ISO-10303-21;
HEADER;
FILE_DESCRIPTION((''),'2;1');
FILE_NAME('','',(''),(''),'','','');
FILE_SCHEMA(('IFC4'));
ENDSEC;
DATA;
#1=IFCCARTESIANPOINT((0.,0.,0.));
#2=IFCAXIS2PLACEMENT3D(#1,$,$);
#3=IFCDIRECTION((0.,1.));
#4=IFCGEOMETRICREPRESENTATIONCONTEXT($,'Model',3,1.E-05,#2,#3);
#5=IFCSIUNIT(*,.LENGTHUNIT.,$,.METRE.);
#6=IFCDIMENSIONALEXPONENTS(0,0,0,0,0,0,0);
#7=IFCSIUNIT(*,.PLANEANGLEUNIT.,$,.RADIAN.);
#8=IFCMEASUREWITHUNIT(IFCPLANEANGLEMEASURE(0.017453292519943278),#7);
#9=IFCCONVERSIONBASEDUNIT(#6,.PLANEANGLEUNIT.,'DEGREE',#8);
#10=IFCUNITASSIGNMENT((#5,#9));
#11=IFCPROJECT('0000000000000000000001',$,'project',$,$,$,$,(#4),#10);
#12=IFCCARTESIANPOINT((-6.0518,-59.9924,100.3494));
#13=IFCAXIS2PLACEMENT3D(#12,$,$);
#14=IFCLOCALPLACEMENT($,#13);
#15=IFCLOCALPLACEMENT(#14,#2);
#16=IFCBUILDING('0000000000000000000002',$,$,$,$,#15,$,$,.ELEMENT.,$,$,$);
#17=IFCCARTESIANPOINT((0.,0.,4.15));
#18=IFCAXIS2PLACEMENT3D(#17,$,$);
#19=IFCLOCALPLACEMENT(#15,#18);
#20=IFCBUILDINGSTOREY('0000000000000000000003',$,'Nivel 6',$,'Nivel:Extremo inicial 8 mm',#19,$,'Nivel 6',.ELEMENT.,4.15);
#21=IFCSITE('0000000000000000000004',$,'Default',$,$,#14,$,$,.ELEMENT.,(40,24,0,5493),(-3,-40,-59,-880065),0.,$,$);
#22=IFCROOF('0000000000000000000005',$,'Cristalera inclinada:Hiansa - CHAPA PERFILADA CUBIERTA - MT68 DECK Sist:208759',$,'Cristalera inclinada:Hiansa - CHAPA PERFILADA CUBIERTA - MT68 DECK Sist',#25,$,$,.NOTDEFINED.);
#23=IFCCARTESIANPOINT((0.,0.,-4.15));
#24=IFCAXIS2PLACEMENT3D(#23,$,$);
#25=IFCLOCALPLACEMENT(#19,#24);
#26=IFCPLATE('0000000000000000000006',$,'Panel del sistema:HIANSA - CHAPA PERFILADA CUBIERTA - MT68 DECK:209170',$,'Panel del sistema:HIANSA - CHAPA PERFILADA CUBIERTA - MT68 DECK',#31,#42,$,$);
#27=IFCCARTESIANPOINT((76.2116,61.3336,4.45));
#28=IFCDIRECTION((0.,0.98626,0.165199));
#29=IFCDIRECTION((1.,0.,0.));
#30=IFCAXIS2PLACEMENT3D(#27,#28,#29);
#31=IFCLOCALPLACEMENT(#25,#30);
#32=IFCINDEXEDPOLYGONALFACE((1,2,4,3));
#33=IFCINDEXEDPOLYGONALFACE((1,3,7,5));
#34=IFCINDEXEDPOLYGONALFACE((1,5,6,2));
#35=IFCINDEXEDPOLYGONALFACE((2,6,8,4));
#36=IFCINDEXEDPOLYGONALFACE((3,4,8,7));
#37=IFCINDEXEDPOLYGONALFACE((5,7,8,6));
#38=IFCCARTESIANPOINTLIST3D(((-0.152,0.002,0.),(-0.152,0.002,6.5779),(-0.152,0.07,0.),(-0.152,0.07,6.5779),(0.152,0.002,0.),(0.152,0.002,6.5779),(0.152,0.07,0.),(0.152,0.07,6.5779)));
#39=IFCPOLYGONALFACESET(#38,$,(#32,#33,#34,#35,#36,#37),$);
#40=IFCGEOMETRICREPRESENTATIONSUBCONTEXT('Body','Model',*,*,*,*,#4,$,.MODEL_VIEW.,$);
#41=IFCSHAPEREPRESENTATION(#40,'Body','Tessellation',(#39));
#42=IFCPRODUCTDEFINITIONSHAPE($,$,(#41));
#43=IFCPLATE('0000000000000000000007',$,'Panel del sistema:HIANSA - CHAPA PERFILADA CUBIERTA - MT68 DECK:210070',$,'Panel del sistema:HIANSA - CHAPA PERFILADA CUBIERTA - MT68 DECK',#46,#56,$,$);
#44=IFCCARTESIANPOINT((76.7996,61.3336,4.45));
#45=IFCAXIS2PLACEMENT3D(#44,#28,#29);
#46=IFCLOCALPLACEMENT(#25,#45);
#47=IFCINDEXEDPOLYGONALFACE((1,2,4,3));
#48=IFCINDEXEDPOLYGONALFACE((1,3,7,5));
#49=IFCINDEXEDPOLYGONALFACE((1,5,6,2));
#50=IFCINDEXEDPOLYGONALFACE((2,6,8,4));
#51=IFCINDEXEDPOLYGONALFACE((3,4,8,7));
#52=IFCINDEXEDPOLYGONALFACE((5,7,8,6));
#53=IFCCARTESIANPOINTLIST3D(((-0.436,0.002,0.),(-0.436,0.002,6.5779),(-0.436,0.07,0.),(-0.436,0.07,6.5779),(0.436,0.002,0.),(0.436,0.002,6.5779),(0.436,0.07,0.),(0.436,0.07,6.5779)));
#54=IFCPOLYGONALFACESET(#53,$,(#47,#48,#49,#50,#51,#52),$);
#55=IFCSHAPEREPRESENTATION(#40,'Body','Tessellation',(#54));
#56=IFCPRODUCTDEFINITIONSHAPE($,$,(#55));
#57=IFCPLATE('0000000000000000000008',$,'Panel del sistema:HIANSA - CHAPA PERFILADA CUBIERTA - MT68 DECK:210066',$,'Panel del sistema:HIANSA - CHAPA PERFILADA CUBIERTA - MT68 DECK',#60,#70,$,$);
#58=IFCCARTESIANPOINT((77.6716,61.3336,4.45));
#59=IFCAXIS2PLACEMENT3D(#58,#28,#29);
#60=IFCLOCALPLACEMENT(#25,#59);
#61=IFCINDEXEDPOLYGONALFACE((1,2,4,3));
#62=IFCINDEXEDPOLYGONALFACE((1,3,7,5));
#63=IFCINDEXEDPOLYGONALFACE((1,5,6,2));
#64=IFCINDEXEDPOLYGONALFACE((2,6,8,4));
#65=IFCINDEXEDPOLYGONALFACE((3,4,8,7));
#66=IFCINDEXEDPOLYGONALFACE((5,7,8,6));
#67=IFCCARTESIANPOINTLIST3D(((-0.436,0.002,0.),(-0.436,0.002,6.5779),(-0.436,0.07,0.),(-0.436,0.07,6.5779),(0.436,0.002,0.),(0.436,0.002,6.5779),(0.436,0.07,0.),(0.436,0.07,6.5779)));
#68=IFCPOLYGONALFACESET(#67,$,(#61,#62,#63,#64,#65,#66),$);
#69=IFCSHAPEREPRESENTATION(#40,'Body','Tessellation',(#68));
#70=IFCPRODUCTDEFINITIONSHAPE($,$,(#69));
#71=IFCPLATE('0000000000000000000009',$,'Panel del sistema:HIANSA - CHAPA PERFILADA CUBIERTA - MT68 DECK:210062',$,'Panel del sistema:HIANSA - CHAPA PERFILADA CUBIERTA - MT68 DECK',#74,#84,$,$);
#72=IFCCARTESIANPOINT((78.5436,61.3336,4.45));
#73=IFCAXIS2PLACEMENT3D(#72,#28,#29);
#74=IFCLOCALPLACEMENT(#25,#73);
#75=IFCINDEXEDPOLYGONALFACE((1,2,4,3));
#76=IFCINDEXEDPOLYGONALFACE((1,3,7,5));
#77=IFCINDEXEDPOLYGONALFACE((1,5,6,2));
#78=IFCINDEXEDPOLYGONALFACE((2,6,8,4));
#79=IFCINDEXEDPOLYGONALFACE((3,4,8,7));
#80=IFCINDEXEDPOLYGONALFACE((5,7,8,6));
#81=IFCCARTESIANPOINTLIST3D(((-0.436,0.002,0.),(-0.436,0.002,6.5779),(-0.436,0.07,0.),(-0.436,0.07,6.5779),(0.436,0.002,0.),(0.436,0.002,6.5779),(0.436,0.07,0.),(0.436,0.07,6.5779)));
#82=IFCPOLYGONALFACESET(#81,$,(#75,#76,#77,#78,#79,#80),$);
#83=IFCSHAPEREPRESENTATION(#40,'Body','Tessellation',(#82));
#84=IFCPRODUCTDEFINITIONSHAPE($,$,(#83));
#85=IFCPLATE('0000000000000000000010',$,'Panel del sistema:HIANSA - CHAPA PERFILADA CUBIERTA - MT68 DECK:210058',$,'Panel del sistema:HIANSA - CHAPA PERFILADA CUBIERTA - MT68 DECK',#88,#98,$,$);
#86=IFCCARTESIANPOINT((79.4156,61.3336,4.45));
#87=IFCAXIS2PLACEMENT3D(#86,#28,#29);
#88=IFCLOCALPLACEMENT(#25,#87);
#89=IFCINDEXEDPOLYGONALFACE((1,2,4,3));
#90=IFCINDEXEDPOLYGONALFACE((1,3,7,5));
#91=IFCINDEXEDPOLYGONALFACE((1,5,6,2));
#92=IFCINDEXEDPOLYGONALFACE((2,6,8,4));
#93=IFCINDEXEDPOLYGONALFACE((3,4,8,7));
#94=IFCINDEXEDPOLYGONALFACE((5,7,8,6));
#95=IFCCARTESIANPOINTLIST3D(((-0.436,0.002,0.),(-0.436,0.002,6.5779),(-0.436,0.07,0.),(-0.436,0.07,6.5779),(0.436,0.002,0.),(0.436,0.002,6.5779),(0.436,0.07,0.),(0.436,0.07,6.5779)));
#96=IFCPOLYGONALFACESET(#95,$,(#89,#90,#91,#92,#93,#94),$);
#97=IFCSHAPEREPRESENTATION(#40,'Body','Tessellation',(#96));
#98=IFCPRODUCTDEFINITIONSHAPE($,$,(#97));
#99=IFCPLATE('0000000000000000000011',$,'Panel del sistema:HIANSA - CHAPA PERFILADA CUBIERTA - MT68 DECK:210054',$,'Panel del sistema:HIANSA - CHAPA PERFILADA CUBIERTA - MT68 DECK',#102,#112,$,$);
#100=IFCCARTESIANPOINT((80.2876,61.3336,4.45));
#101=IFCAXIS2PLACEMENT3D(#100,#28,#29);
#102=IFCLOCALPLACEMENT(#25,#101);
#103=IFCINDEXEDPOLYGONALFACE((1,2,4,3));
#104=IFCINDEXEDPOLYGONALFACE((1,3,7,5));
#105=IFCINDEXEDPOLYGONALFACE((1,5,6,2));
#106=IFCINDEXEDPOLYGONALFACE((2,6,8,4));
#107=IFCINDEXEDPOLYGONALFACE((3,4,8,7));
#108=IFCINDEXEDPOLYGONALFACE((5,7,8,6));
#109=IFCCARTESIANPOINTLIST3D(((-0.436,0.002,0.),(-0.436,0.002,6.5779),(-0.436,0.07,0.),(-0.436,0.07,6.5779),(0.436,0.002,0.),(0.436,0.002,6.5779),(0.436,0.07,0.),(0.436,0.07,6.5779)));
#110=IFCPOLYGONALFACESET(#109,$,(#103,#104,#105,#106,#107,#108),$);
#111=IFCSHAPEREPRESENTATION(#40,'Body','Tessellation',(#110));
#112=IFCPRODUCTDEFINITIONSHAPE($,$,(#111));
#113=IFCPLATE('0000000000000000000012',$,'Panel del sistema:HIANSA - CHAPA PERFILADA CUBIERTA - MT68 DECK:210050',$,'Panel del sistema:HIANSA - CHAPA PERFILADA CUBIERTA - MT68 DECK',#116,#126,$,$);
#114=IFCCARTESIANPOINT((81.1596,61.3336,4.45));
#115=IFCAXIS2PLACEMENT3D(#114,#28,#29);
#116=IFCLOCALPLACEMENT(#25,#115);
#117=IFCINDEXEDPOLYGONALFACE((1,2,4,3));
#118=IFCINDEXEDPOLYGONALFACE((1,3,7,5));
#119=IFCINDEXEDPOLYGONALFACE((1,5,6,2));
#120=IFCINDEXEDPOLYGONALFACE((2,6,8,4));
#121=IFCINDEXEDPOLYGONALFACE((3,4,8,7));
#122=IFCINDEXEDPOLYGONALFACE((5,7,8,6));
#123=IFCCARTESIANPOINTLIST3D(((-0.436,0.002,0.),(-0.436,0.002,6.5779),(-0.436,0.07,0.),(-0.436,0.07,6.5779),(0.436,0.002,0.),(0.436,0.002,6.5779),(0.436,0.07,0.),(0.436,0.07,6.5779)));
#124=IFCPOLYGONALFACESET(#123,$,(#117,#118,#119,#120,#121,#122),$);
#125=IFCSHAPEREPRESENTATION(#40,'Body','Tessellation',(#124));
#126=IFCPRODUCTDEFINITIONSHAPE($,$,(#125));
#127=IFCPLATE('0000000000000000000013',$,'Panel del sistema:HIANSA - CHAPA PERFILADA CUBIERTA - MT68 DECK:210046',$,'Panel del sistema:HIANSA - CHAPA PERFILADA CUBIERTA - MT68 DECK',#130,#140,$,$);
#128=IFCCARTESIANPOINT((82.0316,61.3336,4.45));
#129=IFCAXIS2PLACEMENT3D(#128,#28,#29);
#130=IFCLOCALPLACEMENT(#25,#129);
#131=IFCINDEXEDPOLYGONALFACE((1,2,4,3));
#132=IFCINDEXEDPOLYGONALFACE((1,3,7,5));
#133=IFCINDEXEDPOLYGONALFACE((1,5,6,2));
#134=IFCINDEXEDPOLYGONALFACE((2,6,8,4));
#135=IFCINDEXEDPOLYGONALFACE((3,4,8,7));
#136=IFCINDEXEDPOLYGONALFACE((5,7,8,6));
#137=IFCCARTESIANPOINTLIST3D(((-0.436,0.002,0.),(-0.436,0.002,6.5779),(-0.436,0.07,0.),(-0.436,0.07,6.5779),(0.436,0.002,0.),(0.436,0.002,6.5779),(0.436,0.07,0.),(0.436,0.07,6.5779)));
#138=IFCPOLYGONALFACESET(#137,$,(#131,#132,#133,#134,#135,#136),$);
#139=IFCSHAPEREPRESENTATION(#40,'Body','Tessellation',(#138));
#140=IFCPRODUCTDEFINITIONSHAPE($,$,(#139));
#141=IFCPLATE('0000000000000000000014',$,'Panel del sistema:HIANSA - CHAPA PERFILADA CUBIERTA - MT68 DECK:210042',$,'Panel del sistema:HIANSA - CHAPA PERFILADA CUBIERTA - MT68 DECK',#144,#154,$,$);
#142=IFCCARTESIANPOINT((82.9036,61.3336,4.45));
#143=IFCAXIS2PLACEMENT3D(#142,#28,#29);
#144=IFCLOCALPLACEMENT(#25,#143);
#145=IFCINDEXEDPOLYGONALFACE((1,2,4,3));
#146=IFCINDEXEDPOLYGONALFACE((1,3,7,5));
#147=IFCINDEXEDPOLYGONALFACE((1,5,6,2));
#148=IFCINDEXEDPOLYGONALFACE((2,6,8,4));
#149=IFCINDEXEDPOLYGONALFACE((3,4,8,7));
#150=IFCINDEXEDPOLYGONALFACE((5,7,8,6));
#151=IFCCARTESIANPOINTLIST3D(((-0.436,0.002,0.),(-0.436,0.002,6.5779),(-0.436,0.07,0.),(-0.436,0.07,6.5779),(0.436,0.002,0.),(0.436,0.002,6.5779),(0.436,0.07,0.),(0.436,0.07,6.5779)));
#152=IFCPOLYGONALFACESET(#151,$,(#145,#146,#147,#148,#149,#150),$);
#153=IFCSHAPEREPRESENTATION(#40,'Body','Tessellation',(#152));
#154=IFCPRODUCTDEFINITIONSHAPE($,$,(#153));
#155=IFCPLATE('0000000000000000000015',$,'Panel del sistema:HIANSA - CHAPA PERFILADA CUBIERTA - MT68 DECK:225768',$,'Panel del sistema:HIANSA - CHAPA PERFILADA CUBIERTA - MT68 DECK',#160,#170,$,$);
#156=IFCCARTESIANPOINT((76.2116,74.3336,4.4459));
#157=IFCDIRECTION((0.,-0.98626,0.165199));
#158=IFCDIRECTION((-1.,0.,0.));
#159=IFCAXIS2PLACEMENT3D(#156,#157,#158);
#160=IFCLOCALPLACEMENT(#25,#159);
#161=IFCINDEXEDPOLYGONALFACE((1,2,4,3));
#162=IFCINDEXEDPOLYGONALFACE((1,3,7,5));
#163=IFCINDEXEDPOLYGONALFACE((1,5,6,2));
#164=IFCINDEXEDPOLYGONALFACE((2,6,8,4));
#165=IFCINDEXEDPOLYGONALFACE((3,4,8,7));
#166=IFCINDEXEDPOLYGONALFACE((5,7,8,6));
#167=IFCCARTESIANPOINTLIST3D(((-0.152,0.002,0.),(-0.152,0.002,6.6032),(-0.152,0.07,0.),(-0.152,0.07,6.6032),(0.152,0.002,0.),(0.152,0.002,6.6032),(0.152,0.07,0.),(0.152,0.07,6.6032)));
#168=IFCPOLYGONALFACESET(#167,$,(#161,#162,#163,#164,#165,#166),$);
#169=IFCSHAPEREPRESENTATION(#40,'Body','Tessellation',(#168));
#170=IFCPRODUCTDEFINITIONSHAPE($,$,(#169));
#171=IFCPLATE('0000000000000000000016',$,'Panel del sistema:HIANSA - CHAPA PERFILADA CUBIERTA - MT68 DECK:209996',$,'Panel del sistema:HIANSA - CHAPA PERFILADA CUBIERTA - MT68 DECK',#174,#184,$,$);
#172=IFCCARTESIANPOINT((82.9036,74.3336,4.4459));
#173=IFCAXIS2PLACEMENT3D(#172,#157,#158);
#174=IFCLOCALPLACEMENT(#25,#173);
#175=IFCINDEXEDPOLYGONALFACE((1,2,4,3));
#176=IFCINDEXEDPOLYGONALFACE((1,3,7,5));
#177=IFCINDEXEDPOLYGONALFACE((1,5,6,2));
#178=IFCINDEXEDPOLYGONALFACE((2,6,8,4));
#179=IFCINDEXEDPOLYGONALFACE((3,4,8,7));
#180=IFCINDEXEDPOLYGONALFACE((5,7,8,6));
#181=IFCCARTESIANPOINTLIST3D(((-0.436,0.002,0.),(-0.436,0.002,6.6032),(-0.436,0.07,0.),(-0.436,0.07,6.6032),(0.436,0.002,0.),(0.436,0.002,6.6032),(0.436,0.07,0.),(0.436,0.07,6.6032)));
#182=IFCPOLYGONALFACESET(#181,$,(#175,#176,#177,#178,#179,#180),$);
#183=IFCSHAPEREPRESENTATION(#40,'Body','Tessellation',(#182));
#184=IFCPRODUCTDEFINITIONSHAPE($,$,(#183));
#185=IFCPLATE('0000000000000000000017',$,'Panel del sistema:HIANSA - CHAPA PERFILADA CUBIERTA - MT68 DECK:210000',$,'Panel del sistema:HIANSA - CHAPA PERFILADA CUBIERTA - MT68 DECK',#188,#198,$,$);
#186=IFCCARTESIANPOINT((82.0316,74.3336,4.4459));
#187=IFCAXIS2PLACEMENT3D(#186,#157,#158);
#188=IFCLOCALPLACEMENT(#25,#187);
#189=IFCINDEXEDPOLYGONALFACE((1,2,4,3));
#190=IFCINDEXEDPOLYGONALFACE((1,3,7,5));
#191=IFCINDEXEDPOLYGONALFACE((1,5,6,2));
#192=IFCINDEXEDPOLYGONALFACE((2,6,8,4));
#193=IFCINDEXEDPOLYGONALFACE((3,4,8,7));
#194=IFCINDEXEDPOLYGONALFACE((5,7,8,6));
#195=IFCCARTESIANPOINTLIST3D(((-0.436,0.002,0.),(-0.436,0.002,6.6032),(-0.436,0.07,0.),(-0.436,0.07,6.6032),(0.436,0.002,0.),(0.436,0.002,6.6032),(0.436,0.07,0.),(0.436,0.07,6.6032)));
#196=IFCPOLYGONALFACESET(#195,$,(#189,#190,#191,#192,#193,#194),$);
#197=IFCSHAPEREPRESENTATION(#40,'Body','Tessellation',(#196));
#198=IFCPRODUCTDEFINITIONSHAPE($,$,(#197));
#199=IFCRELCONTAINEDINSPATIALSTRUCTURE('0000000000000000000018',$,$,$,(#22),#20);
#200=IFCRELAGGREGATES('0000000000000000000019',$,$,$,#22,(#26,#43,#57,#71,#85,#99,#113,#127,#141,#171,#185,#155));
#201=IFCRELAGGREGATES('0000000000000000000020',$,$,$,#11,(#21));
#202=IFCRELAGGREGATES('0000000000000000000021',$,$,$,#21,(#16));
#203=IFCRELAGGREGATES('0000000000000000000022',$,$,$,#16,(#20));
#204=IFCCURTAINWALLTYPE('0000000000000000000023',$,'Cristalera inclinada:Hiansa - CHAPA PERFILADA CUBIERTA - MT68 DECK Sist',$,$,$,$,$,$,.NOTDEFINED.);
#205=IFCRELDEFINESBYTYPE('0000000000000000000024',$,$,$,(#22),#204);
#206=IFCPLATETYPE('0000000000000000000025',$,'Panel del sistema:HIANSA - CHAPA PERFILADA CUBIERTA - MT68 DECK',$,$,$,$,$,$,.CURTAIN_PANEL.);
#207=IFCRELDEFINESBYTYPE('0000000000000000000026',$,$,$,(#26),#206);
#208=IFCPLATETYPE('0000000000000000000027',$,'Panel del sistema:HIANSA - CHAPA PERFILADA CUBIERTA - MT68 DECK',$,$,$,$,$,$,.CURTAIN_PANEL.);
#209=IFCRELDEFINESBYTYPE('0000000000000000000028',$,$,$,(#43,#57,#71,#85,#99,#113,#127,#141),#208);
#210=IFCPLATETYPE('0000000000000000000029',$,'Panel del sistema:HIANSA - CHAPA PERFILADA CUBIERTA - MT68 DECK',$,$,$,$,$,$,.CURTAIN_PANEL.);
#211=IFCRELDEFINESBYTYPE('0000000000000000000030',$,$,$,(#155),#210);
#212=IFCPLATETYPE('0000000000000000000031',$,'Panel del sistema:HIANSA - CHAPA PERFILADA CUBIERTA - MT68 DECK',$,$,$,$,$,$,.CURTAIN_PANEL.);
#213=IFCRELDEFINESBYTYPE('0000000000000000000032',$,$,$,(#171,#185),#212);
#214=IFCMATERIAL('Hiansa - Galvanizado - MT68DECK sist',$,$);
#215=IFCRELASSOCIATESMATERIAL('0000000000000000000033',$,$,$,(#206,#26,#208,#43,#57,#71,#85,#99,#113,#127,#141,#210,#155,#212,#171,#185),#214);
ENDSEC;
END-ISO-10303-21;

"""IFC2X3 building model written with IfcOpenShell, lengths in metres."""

from ifc_helpers import new_model, entity, si_unit, converted_unit, direction, frame, origin, origin_2d_with_axis, place, context, subcontext, project, spatial, rectangle, extrude, source, transform, mapped, material, type_object, type_shapes, element, aggregate, save


model = new_model("IFC2X3")

# Units and contexts
model_context = context("Model", 3, precision=1e-05, world=origin(), true_north=direction((0.0, 1.0)))
body_context = subcontext(model_context, "Body", "Model", "MODEL_VIEW")
ifc_project = project(units=[si_unit("LENGTHUNIT", "METRE"), converted_unit("PLANEANGLEUNIT", "DEGREE", entity("IfcPlaneAngleMeasure", 0.017453292519943278), si_unit("PLANEANGLEUNIT", "RADIAN"), dimensions=[0, 0, 0, 0, 0, 0, 0])], contexts=[model_context])

# Site, building, storey
site_placement = place(None, frame((-6.0518, -59.9924, 100.3494)))
site = spatial("IfcSite", under=ifc_project, at=site_placement, Name="Default", CompositionType="ELEMENT", RefLatitude=(40, 24, 0, 5493), RefLongitude=(-3, -40, -59, -880065), RefElevation=0.0)
building_placement = place(site_placement, origin())
building = spatial("IfcBuilding", under=site, at=building_placement, CompositionType="ELEMENT")
storey_placement = place(building_placement, frame((0.0, 0.0, 4.15)))
storey = spatial("IfcBuildingStorey", under=building, at=storey_placement, Name="Nivel 6", ObjectType="Nivel:Extremo inicial 8 mm", LongName="Nivel 6", CompositionType="ELEMENT", Elevation=4.15)

# Roof, plates
curtain_wall_type = type_object("IfcCurtainWallType", Name="Cristalera inclinada:Hiansa - CHAPA PERFILADA CUBIERTA - MT68 DECK Sist", PredefinedType="NOTDEFINED")
roof_placement = place(storey_placement, frame((0.0, 0.0, -4.15)))
roof = element("IfcRoof", 1, at=roof_placement, inside=storey, type_object=curtain_wall_type, Name="Cristalera inclinada:Hiansa - CHAPA PERFILADA CUBIERTA - MT68 DECK Sist:208759", ObjectType="Cristalera inclinada:Hiansa - CHAPA PERFILADA CUBIERTA - MT68 DECK Sist", ShapeType="NOTDEFINED")
ifc_material_1 = material(Name="Hiansa - Galvanizado - MT68DECK sist")
plate_type_1 = type_object("IfcPlateType", Name="Panel del sistema:HIANSA - CHAPA PERFILADA CUBIERTA - MT68 DECK", PredefinedType="CURTAIN_PANEL", material=ifc_material_1)
shared_shape_1 = source(origin(), body_context, "Body", "SweptSolid", [
    extrude(rectangle(XDim=0.068, YDim=0.304, at=origin_2d_with_axis()), frame((0.0, 0.036, 0.0), z_axis=(0.0, 0.0, 1.0), x_axis=(0.0, 1.0, 0.0)), (0.0, 0.0, 1.0), 6.5779),
])
type_shapes(plate_type_1, [shared_shape_1])
plate_1_placement = place(roof_placement, frame((76.2116, 61.3336, 4.45), z_axis=(0.0, 0.98626, 0.165199), x_axis=(1.0, 0.0, 0.0)))
plate_1 = element("IfcPlate", 2, at=plate_1_placement, type_object=plate_type_1, material=ifc_material_1, Name="Panel del sistema:HIANSA - CHAPA PERFILADA CUBIERTA - MT68 DECK:209170", ObjectType="Panel del sistema:HIANSA - CHAPA PERFILADA CUBIERTA - MT68 DECK", context=body_context, shape_type="MappedRepresentation", body=[
    mapped(shared_shape_1, transform((0.0, 0.0, 0.0), scale=1.0)),
])
plate_type_2 = type_object("IfcPlateType", Name="Panel del sistema:HIANSA - CHAPA PERFILADA CUBIERTA - MT68 DECK", PredefinedType="CURTAIN_PANEL", material=ifc_material_1)
shared_shape_2 = source(origin(), body_context, "Body", "SweptSolid", [
    extrude(rectangle(XDim=0.068, YDim=0.872, at=origin_2d_with_axis()), frame((0.0, 0.036, 0.0), z_axis=(0.0, 0.0, 1.0), x_axis=(0.0, 1.0, 0.0)), (0.0, 0.0, 1.0), 6.5779),
])
type_shapes(plate_type_2, [shared_shape_2])
plate_2_placement = place(roof_placement, frame((76.7996, 61.3336, 4.45), z_axis=(0.0, 0.98626, 0.165199), x_axis=(1.0, 0.0, 0.0)))
plate_2 = element("IfcPlate", 3, at=plate_2_placement, type_object=plate_type_2, material=ifc_material_1, Name="Panel del sistema:HIANSA - CHAPA PERFILADA CUBIERTA - MT68 DECK:210070", ObjectType="Panel del sistema:HIANSA - CHAPA PERFILADA CUBIERTA - MT68 DECK", context=body_context, shape_type="MappedRepresentation", body=[
    mapped(shared_shape_2, transform((0.0, 0.0, 0.0), scale=1.0)),
])
plate_3_placement = place(roof_placement, frame((77.6716, 61.3336, 4.45), z_axis=(0.0, 0.98626, 0.165199), x_axis=(1.0, 0.0, 0.0)))
plate_3 = element("IfcPlate", 4, at=plate_3_placement, type_object=plate_type_2, material=ifc_material_1, Name="Panel del sistema:HIANSA - CHAPA PERFILADA CUBIERTA - MT68 DECK:210066", ObjectType="Panel del sistema:HIANSA - CHAPA PERFILADA CUBIERTA - MT68 DECK", context=body_context, shape_type="MappedRepresentation", body=[
    mapped(shared_shape_2, transform((0.0, 0.0, 0.0), scale=1.0)),
])
plate_4_placement = place(roof_placement, frame((78.5436, 61.3336, 4.45), z_axis=(0.0, 0.98626, 0.165199), x_axis=(1.0, 0.0, 0.0)))
plate_4 = element("IfcPlate", 5, at=plate_4_placement, type_object=plate_type_2, material=ifc_material_1, Name="Panel del sistema:HIANSA - CHAPA PERFILADA CUBIERTA - MT68 DECK:210062", ObjectType="Panel del sistema:HIANSA - CHAPA PERFILADA CUBIERTA - MT68 DECK", context=body_context, shape_type="MappedRepresentation", body=[
    mapped(shared_shape_2, transform((0.0, 0.0, 0.0), scale=1.0)),
])
plate_5_placement = place(roof_placement, frame((79.4156, 61.3336, 4.45), z_axis=(0.0, 0.98626, 0.165199), x_axis=(1.0, 0.0, 0.0)))
plate_5 = element("IfcPlate", 6, at=plate_5_placement, type_object=plate_type_2, material=ifc_material_1, Name="Panel del sistema:HIANSA - CHAPA PERFILADA CUBIERTA - MT68 DECK:210058", ObjectType="Panel del sistema:HIANSA - CHAPA PERFILADA CUBIERTA - MT68 DECK", context=body_context, shape_type="MappedRepresentation", body=[
    mapped(shared_shape_2, transform((0.0, 0.0, 0.0), scale=1.0)),
])
plate_6_placement = place(roof_placement, frame((80.2876, 61.3336, 4.45), z_axis=(0.0, 0.98626, 0.165199), x_axis=(1.0, 0.0, 0.0)))
plate_6 = element("IfcPlate", 7, at=plate_6_placement, type_object=plate_type_2, material=ifc_material_1, Name="Panel del sistema:HIANSA - CHAPA PERFILADA CUBIERTA - MT68 DECK:210054", ObjectType="Panel del sistema:HIANSA - CHAPA PERFILADA CUBIERTA - MT68 DECK", context=body_context, shape_type="MappedRepresentation", body=[
    mapped(shared_shape_2, transform((0.0, 0.0, 0.0), scale=1.0)),
])
plate_7_placement = place(roof_placement, frame((81.1596, 61.3336, 4.45), z_axis=(0.0, 0.98626, 0.165199), x_axis=(1.0, 0.0, 0.0)))
plate_7 = element("IfcPlate", 8, at=plate_7_placement, type_object=plate_type_2, material=ifc_material_1, Name="Panel del sistema:HIANSA - CHAPA PERFILADA CUBIERTA - MT68 DECK:210050", ObjectType="Panel del sistema:HIANSA - CHAPA PERFILADA CUBIERTA - MT68 DECK", context=body_context, shape_type="MappedRepresentation", body=[
    mapped(shared_shape_2, transform((0.0, 0.0, 0.0), scale=1.0)),
])
plate_8_placement = place(roof_placement, frame((82.0316, 61.3336, 4.45), z_axis=(0.0, 0.98626, 0.165199), x_axis=(1.0, 0.0, 0.0)))
plate_8 = element("IfcPlate", 9, at=plate_8_placement, type_object=plate_type_2, material=ifc_material_1, Name="Panel del sistema:HIANSA - CHAPA PERFILADA CUBIERTA - MT68 DECK:210046", ObjectType="Panel del sistema:HIANSA - CHAPA PERFILADA CUBIERTA - MT68 DECK", context=body_context, shape_type="MappedRepresentation", body=[
    mapped(shared_shape_2, transform((0.0, 0.0, 0.0), scale=1.0)),
])
plate_9_placement = place(roof_placement, frame((82.9036, 61.3336, 4.45), z_axis=(0.0, 0.98626, 0.165199), x_axis=(1.0, 0.0, 0.0)))
plate_9 = element("IfcPlate", 10, at=plate_9_placement, type_object=plate_type_2, material=ifc_material_1, Name="Panel del sistema:HIANSA - CHAPA PERFILADA CUBIERTA - MT68 DECK:210042", ObjectType="Panel del sistema:HIANSA - CHAPA PERFILADA CUBIERTA - MT68 DECK", context=body_context, shape_type="MappedRepresentation", body=[
    mapped(shared_shape_2, transform((0.0, 0.0, 0.0), scale=1.0)),
])
plate_type_3 = type_object("IfcPlateType", Name="Panel del sistema:HIANSA - CHAPA PERFILADA CUBIERTA - MT68 DECK", PredefinedType="CURTAIN_PANEL", material=ifc_material_1)
shared_shape_3 = source(origin(), body_context, "Body", "SweptSolid", [
    extrude(rectangle(XDim=0.068, YDim=0.304, at=origin_2d_with_axis()), frame((0.0, 0.036, 0.0), z_axis=(0.0, 0.0, 1.0), x_axis=(0.0, 1.0, 0.0)), (0.0, 0.0, 1.0), 6.6032),
])
type_shapes(plate_type_3, [shared_shape_3])
plate_10_placement = place(roof_placement, frame((76.2116, 74.3336, 4.4459), z_axis=(0.0, -0.98626, 0.165199), x_axis=(-1.0, 0.0, 0.0)))
plate_10 = element("IfcPlate", 11, at=plate_10_placement, type_object=plate_type_3, material=ifc_material_1, Name="Panel del sistema:HIANSA - CHAPA PERFILADA CUBIERTA - MT68 DECK:225768", ObjectType="Panel del sistema:HIANSA - CHAPA PERFILADA CUBIERTA - MT68 DECK", context=body_context, shape_type="MappedRepresentation", body=[
    mapped(shared_shape_3, transform((0.0, 0.0, 0.0), scale=1.0)),
])
plate_type_4 = type_object("IfcPlateType", Name="Panel del sistema:HIANSA - CHAPA PERFILADA CUBIERTA - MT68 DECK", PredefinedType="CURTAIN_PANEL", material=ifc_material_1)
shared_shape_4 = source(origin(), body_context, "Body", "SweptSolid", [
    extrude(rectangle(XDim=0.068, YDim=0.872, at=origin_2d_with_axis()), frame((0.0, 0.036, 0.0), z_axis=(0.0, 0.0, 1.0), x_axis=(0.0, 1.0, 0.0)), (0.0, 0.0, 1.0), 6.6032),
])
type_shapes(plate_type_4, [shared_shape_4])
plate_11_placement = place(roof_placement, frame((82.9036, 74.3336, 4.4459), z_axis=(0.0, -0.98626, 0.165199), x_axis=(-1.0, 0.0, 0.0)))
plate_11 = element("IfcPlate", 12, at=plate_11_placement, type_object=plate_type_4, material=ifc_material_1, Name="Panel del sistema:HIANSA - CHAPA PERFILADA CUBIERTA - MT68 DECK:209996", ObjectType="Panel del sistema:HIANSA - CHAPA PERFILADA CUBIERTA - MT68 DECK", context=body_context, shape_type="MappedRepresentation", body=[
    mapped(shared_shape_4, transform((0.0, 0.0, 0.0), scale=1.0)),
])
plate_12_placement = place(roof_placement, frame((82.0316, 74.3336, 4.4459), z_axis=(0.0, -0.98626, 0.165199), x_axis=(-1.0, 0.0, 0.0)))
plate_12 = element("IfcPlate", 13, at=plate_12_placement, type_object=plate_type_4, material=ifc_material_1, Name="Panel del sistema:HIANSA - CHAPA PERFILADA CUBIERTA - MT68 DECK:210000", ObjectType="Panel del sistema:HIANSA - CHAPA PERFILADA CUBIERTA - MT68 DECK", context=body_context, shape_type="MappedRepresentation", body=[
    mapped(shared_shape_4, transform((0.0, 0.0, 0.0), scale=1.0)),
])
aggregate(roof, [plate_1, plate_2, plate_3, plate_4, plate_5, plate_6, plate_7, plate_8, plate_9, plate_11, plate_12, plate_10])

save(model, "model.ifc")
